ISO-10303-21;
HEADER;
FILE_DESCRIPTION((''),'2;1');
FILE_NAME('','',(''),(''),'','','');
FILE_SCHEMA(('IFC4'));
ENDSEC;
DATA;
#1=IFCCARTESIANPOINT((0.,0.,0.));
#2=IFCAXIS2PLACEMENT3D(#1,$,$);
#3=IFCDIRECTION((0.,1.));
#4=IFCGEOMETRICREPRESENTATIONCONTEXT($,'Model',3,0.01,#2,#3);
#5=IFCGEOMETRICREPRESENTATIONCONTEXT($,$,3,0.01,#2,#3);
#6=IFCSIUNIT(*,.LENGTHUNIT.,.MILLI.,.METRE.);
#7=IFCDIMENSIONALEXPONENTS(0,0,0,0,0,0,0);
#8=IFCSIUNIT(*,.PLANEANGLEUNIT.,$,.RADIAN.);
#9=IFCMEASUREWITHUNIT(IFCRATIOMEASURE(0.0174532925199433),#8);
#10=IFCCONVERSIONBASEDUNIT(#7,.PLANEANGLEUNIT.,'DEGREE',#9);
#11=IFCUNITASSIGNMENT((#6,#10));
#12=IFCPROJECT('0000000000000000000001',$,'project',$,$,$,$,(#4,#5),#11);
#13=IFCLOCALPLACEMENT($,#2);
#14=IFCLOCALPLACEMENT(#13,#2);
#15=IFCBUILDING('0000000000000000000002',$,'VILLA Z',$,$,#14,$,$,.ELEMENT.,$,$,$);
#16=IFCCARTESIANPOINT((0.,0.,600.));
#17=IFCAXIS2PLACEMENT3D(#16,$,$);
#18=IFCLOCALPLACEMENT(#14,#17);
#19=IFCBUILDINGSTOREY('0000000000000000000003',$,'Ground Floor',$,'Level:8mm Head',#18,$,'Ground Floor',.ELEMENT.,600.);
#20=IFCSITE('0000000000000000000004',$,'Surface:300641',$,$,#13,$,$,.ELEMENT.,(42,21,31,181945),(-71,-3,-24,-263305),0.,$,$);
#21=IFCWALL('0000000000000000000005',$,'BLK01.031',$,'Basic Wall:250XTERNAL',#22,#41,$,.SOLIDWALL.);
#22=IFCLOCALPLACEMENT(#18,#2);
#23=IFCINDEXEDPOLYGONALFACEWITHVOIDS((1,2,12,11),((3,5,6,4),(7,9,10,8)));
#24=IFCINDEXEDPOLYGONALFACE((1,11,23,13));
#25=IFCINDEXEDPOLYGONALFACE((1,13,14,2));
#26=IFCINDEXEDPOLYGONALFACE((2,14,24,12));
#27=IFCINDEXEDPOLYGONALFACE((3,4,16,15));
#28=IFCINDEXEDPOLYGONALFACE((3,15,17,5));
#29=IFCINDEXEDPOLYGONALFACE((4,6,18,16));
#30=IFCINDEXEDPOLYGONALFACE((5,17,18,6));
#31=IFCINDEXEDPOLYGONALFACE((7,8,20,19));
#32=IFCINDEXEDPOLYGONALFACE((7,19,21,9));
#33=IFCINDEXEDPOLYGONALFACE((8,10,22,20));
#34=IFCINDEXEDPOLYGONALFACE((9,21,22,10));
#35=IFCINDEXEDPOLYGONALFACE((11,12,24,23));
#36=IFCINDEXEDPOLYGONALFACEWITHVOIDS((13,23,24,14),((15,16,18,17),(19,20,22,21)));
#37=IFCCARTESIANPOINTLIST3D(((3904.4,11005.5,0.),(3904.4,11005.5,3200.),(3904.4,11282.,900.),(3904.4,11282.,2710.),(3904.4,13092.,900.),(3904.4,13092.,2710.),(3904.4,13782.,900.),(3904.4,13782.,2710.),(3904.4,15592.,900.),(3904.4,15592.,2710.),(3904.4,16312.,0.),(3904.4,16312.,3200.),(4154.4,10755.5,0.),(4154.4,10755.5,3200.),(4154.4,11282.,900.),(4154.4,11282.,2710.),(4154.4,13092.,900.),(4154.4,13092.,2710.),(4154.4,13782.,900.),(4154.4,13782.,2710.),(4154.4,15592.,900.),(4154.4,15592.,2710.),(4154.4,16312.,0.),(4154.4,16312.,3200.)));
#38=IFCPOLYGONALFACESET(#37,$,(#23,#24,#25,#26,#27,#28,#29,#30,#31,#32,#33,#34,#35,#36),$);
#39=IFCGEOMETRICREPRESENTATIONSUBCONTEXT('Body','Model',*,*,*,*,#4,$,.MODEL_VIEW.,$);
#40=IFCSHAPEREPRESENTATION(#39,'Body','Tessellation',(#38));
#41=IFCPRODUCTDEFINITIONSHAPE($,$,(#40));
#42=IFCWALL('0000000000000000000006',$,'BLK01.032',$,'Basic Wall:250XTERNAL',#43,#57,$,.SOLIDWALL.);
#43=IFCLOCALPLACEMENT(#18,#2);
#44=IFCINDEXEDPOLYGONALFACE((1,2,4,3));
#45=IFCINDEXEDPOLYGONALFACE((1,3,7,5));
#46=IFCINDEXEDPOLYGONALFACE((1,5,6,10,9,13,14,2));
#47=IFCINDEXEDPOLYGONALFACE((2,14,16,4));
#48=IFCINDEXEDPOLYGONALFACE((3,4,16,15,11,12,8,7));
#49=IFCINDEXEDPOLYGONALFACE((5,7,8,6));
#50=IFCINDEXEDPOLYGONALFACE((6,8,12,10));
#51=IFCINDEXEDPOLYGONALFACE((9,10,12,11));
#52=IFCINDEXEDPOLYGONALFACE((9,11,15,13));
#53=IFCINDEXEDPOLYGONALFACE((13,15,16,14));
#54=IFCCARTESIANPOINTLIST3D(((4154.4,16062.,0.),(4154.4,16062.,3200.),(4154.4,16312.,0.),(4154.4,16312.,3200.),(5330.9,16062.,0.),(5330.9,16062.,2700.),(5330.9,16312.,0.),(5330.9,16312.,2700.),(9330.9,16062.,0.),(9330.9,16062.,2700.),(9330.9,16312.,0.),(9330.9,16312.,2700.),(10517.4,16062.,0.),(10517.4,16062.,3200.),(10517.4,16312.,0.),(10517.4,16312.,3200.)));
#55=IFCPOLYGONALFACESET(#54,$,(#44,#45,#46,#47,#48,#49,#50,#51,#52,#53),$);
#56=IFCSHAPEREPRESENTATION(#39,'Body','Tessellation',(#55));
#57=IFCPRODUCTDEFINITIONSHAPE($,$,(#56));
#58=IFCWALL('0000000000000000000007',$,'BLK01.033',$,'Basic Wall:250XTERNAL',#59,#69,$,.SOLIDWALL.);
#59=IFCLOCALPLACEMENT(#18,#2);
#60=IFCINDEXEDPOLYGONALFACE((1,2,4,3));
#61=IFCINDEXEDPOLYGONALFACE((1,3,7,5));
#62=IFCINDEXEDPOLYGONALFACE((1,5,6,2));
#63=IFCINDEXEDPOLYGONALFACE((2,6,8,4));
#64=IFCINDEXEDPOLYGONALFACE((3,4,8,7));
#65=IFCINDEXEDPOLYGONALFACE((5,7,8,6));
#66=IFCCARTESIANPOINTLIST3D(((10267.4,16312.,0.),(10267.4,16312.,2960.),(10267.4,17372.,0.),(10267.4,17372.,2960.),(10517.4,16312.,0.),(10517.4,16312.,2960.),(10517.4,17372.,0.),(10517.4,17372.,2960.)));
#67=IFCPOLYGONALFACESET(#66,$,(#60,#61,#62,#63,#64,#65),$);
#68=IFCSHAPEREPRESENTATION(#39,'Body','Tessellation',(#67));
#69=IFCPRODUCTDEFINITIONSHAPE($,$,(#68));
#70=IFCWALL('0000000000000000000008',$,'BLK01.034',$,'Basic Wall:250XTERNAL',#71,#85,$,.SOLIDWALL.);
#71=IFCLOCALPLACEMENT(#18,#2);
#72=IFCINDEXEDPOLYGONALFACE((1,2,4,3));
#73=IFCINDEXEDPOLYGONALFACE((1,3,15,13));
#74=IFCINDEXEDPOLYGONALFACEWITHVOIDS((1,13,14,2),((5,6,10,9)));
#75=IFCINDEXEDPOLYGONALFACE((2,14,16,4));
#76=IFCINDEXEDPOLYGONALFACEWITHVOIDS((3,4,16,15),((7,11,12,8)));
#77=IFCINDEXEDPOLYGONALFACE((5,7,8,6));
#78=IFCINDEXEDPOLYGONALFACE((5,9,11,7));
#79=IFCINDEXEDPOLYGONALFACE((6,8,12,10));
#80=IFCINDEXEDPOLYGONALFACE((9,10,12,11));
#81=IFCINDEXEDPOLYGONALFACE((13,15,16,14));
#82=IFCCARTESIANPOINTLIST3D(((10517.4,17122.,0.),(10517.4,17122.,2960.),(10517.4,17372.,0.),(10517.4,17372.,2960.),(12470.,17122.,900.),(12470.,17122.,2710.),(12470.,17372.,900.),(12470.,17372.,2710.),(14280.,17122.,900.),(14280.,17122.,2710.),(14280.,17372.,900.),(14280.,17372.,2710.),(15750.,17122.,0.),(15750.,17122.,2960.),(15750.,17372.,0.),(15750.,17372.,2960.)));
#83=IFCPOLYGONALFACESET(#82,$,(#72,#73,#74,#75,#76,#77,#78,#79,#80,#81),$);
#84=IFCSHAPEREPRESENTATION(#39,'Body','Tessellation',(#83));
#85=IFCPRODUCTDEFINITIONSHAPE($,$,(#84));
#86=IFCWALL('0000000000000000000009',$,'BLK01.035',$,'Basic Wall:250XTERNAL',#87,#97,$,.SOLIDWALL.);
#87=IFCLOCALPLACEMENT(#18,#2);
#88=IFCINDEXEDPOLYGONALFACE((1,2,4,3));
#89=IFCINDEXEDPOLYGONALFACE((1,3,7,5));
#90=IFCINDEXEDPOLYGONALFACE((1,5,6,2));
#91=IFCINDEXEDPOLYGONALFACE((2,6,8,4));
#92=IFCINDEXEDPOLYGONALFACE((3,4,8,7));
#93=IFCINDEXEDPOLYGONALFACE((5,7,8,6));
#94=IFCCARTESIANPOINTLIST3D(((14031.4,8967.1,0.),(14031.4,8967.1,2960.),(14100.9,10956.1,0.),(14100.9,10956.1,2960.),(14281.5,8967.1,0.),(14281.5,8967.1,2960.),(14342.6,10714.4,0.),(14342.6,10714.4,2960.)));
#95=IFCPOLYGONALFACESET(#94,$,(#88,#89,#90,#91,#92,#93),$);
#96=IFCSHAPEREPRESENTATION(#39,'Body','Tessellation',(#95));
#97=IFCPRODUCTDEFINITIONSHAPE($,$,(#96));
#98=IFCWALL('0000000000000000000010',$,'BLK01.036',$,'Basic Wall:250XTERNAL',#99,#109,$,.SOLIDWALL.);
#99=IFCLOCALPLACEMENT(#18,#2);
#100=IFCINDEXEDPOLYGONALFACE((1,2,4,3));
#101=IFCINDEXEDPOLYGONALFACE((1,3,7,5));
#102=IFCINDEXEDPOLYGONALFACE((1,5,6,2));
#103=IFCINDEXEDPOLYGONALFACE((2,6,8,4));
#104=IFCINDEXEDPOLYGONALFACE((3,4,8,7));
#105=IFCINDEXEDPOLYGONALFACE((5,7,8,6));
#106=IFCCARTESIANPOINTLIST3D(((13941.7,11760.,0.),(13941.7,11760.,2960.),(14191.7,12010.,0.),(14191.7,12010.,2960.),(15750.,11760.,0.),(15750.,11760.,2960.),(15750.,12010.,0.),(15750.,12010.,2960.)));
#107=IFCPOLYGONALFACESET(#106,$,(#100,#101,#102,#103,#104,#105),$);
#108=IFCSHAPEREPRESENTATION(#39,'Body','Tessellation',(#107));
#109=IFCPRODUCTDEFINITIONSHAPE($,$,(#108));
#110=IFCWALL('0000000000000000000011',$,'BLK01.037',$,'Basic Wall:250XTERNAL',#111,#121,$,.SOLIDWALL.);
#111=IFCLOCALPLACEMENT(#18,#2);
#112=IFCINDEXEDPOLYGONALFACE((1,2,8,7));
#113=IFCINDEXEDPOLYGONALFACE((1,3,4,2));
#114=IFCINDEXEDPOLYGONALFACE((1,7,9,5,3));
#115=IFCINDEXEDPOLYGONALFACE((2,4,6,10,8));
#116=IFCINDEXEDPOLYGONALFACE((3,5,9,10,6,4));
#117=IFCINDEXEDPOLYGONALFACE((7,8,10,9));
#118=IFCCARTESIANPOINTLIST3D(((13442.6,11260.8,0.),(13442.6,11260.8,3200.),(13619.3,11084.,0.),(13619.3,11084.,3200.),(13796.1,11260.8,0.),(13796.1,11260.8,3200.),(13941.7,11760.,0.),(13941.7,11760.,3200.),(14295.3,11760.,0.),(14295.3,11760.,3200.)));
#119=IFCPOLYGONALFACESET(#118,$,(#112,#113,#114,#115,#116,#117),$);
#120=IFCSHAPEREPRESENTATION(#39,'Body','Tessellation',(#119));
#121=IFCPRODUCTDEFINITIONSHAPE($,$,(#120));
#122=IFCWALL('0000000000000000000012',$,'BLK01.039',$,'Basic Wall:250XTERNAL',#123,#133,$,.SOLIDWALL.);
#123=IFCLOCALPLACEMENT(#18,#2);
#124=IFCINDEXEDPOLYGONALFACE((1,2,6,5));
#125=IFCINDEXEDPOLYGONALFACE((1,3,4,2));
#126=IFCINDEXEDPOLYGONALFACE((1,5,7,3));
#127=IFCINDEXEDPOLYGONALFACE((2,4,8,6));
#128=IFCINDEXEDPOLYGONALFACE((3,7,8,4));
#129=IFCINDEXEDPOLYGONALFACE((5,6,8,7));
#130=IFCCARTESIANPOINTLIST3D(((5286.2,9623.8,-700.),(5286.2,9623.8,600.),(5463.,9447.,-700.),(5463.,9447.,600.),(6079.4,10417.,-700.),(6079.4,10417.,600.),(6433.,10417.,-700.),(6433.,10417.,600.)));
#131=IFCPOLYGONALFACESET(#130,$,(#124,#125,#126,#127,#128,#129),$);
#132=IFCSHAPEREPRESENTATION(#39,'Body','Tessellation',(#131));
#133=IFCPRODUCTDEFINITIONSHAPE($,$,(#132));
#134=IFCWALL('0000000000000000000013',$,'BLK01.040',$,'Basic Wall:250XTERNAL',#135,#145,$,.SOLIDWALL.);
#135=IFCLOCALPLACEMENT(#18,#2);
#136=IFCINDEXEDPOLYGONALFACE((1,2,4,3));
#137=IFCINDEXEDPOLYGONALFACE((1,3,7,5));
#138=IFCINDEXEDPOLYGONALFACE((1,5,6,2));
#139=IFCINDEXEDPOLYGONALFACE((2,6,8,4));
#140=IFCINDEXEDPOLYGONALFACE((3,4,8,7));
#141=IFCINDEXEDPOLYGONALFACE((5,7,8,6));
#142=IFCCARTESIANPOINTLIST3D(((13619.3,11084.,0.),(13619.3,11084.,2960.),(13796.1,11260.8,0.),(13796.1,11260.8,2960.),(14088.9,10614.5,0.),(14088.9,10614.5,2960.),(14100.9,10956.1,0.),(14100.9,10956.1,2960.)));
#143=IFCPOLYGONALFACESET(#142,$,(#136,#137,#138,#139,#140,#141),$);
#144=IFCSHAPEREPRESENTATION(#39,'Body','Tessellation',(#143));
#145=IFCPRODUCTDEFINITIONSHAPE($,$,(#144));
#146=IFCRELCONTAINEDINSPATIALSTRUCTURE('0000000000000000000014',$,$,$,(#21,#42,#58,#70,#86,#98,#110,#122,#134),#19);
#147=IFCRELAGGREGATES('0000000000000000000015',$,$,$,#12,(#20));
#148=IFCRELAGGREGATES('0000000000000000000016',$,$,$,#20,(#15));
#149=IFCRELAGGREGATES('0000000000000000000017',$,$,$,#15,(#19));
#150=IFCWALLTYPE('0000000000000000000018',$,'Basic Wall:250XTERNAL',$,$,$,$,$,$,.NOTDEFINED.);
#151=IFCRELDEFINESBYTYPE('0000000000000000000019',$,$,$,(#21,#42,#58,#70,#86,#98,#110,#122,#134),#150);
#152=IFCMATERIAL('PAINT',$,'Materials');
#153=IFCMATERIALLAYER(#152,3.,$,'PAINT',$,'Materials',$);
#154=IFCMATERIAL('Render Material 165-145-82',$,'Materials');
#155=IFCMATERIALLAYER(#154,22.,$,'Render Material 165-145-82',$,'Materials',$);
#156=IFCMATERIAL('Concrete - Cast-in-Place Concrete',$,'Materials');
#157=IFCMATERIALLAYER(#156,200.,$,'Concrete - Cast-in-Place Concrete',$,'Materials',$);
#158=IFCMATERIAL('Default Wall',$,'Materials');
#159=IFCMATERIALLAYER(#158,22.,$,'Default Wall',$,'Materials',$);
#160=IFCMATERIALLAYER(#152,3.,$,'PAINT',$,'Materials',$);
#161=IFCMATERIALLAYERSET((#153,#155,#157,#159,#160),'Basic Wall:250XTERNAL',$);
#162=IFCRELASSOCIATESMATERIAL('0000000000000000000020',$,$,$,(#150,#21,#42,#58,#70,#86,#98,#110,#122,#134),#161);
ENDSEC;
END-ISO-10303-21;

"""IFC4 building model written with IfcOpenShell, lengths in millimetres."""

from ifc_helpers import new_model, entity, si_unit, converted_unit, direction, frame, frame_2d, origin, place, context, subcontext, project, spatial, polyline, rectangle, outline, extrude, clip, halfspace, bounded_halfspace, material, layer, layer_set, layer_usage, type_object, element, save


model = new_model("IFC4")

# Units and contexts
model_context = context("Model", 3, precision=0.01, world=origin(), true_north=direction((0.0, 1.0)))
context_of_model = context(None, 3, precision=0.01, world=origin(), true_north=direction((0.0, 1.0)))
body_context = subcontext(model_context, "Body", "Model", "MODEL_VIEW")
ifc_project = project(units=[si_unit("LENGTHUNIT", "METRE", prefix="MILLI"), converted_unit("PLANEANGLEUNIT", "DEGREE", entity("IfcRatioMeasure", 0.0174532925199433), si_unit("PLANEANGLEUNIT", "RADIAN"), dimensions=[0, 0, 0, 0, 0, 0, 0])], contexts=[model_context, context_of_model])

# Site, building, storey
site_placement = place(None, origin())
site = spatial("IfcSite", under=ifc_project, at=site_placement, Name="Surface:300641", CompositionType="ELEMENT", RefLatitude=(42, 21, 31, 181945), RefLongitude=(-71, -3, -24, -263305), RefElevation=0.0)
building_placement = place(site_placement, origin())
building = spatial("IfcBuilding", under=site, at=building_placement, Name="VILLA Z", CompositionType="ELEMENT")
storey_placement = place(building_placement, frame((0.0, 0.0, 600.0)))
storey = spatial("IfcBuildingStorey", under=building, at=storey_placement, Name="Ground Floor", ObjectType="Level:8mm Head", LongName="Ground Floor", CompositionType="ELEMENT", Elevation=600.0)

# Shared definitions
ifc_material_1 = material(Name="PAINT", Category="Materials")
ifc_layer_1 = layer(ifc_material_1, 3.0, Name="PAINT", Category="Materials")
ifc_material_2 = material(Name="Render Material 165-145-82", Category="Materials")
ifc_layer_2 = layer(ifc_material_2, 22.0, Name="Render Material 165-145-82", Category="Materials")
ifc_material_3 = material(Name="Concrete - Cast-in-Place Concrete", Category="Materials")
ifc_layer_3 = layer(ifc_material_3, 200.0, Name="Concrete - Cast-in-Place Concrete", Category="Materials")
ifc_material_4 = material(Name="Default Wall", Category="Materials")
ifc_layer_4 = layer(ifc_material_4, 22.0, Name="Default Wall", Category="Materials")
ifc_layer_5 = layer(ifc_material_1, 3.0, Name="PAINT", Category="Materials")
ifc_layer_set_1 = layer_set([ifc_layer_1, ifc_layer_2, ifc_layer_3, ifc_layer_4, ifc_layer_5], Name="Basic Wall:250XTERNAL")
wall_type_1 = type_object("IfcWallType", Name="Basic Wall:250XTERNAL", PredefinedType="NOTDEFINED", material=ifc_layer_set_1)

# Wall, openings
ifc_layer_usage_1 = layer_usage(ifc_layer_set_1, "AXIS2", "NEGATIVE", 125.0)
wall_1_placement = place(storey_placement, frame((4029.4, 10755.5, 0.0), z_axis=(0.0, 0.0, 1.0), x_axis=(0.0, 1.0, 0.0)))
wall_1 = element("IfcWall", 1, at=wall_1_placement, inside=storey, type_object=wall_type_1, material=ifc_layer_usage_1, Name="BLK01.031", ObjectType="Basic Wall:250XTERNAL", PredefinedType="SOLIDWALL", context=body_context, shape_type="Clipping", body=[
    clip(extrude(outline(polyline([(5556.5, -125.0), (5556.5, 125.0), (250.0, 125.0), (0.0, -125.0), (5306.5, -125.0), (5556.5, -125.0)])), origin(), (0.0, 0.0, 1.0), 3200.0), halfspace(origin(), True)),
])
opening_1_placement = place(wall_1_placement, frame((526.5, -125.0, 900.0)))
element("IfcOpeningElement", 2, at=opening_1_placement, cuts=wall_1, ObjectType="Opening", PredefinedType="OPENING", context=body_context, shape_type="SweptSolid", body=[
    extrude(rectangle(XDim=1810.0, YDim=1810.0, at=frame_2d((905.0, 905.0), x_axis=(-1.0, 0.0))), frame((0.0, 0.0, 0.0), z_axis=(0.0, 1.0, 0.0), x_axis=(0.0, 0.0, 1.0)), (0.0, 0.0, 1.0), 250.0),
])
opening_2_placement = place(wall_1_placement, frame((3026.5, -125.0, 900.0)))
element("IfcOpeningElement", 3, at=opening_2_placement, cuts=wall_1, ObjectType="Opening", PredefinedType="OPENING", context=body_context, shape_type="SweptSolid", body=[
    extrude(rectangle(XDim=1810.0, YDim=1810.0, at=frame_2d((905.0, 905.0), x_axis=(-1.0, 0.0))), frame((0.0, 0.0, 0.0), z_axis=(0.0, 1.0, 0.0), x_axis=(0.0, 0.0, 1.0)), (0.0, 0.0, 1.0), 250.0),
])

# Wall, opening
ifc_layer_usage_2 = layer_usage(ifc_layer_set_1, "AXIS2", "NEGATIVE", 125.0)
wall_2_placement = place(storey_placement, frame((4154.4, 16187.0, 0.0)))
wall_2 = element("IfcWall", 4, at=wall_2_placement, inside=storey, type_object=wall_type_1, material=ifc_layer_usage_2, Name="BLK01.032", ObjectType="Basic Wall:250XTERNAL", PredefinedType="SOLIDWALL", context=body_context, shape_type="Clipping", body=[
    clip(extrude(rectangle(XDim=6362.9, YDim=250.0, at=frame_2d((3181.5, 0.0), x_axis=(-1.0, 0.0))), origin(), (0.0, 0.0, 1.0), 3200.0), halfspace(origin(), True)),
])
opening_3_placement = place(wall_2_placement, frame((5176.5, 125.0, 0.0)))
element("IfcOpeningElement", 5, at=opening_3_placement, cuts=wall_2, ObjectType="Opening", PredefinedType="OPENING", context=body_context, shape_type="SweptSolid", body=[
    extrude(rectangle(XDim=2700.0, YDim=4000.0, at=frame_2d((1350.0, 2000.0), x_axis=(-1.0, 0.0))), frame((0.0, 0.0, 0.0), z_axis=(0.0, -1.0, 0.0), x_axis=(0.0, 0.0, 1.0)), (0.0, 0.0, 1.0), 250.0),
])

# Wall
ifc_layer_usage_3 = layer_usage(ifc_layer_set_1, "AXIS2", "NEGATIVE", 125.0)
wall_3_placement = place(storey_placement, frame((10392.4, 16312.0, 0.0), z_axis=(0.0, 0.0, 1.0), x_axis=(0.0, 1.0, 0.0)))
element("IfcWall", 6, at=wall_3_placement, inside=storey, type_object=wall_type_1, material=ifc_layer_usage_3, Name="BLK01.033", ObjectType="Basic Wall:250XTERNAL", PredefinedType="SOLIDWALL", context=body_context, shape_type="Clipping", body=[
    clip(extrude(rectangle(XDim=1060.0, YDim=250.0, at=frame_2d((530.0, 0.0), x_axis=(-1.0, 0.0))), origin(), (0.0, 0.0, 1.0), 2960.0), bounded_halfspace(frame((0.0, -125.0, 2960.0), z_axis=(0.0, 0.0, -1.0), x_axis=(-1.0, 0.0, 0.0)), True, frame((0.0, -125.0, 2960.0)), polyline([(0.0, 0.0), (810.0, 0.0), (1060.0, 0.0), (1060.0, 250.0), (0.0, 250.0), (0.0, 0.0)]))),
])

# Wall, opening
ifc_layer_usage_4 = layer_usage(ifc_layer_set_1, "AXIS2", "NEGATIVE", 125.0)
wall_4_placement = place(storey_placement, frame((10517.4, 17247.0, 0.0)))
wall_4 = element("IfcWall", 7, at=wall_4_placement, inside=storey, type_object=wall_type_1, material=ifc_layer_usage_4, Name="BLK01.034", ObjectType="Basic Wall:250XTERNAL", PredefinedType="SOLIDWALL", context=body_context, shape_type="Clipping", body=[
    clip(extrude(rectangle(XDim=5232.6, YDim=250.0, at=frame_2d((2616.3, 0.0), x_axis=(-1.0, 0.0))), origin(), (0.0, 0.0, 1.0), 2960.0), bounded_halfspace(frame((0.0, -125.0, 2960.0), z_axis=(0.0, 0.0, -1.0), x_axis=(0.0, -1.0, 0.0)), True, frame((0.0, -125.0, 2960.0)), polyline([(0.0, 0.0), (5232.6, 0.0), (5232.6, 250.0), (0.0, 250.0), (0.0, 0.0)]))),
])
opening_4_placement = place(wall_4_placement, frame((1952.6, -125.0, 900.0)))
element("IfcOpeningElement", 8, at=opening_4_placement, cuts=wall_4, ObjectType="Opening", PredefinedType="OPENING", context=body_context, shape_type="SweptSolid", body=[
    extrude(rectangle(XDim=1810.0, YDim=1810.0, at=frame_2d((905.0, 905.0), x_axis=(-1.0, 0.0))), frame((0.0, 0.0, 0.0), z_axis=(0.0, 1.0, 0.0), x_axis=(0.0, 0.0, 1.0)), (0.0, 0.0, 1.0), 250.0),
])

# Walls
ifc_layer_usage_5 = layer_usage(ifc_layer_set_1, "AXIS2", "NEGATIVE", 125.0)
wall_5_placement = place(storey_placement, frame((14156.3, 8962.8, 0.0), z_axis=(0.0, 0.0, 1.0), x_axis=(0.034899, 0.999391, 0.0)))
element("IfcWall", 9, at=wall_5_placement, inside=storey, type_object=wall_type_1, material=ifc_layer_usage_5, Name="BLK01.035", ObjectType="Basic Wall:250XTERNAL", PredefinedType="SOLIDWALL", context=body_context, shape_type="Clipping", body=[
    clip(clip(extrude(outline(polyline([(1757.0, -125.0), (1990.2, 125.0), (1648.3, 125.0), (0.0, 125.0), (8.7, -125.0), (1757.0, -125.0)])), origin(), (0.0, 0.0, 1.0), 2960.0), bounded_halfspace(frame((8.7, -125.0, 2960.0), z_axis=(0.0, 0.0, -1.0), x_axis=(-0.999391, -0.034899, 0.0)), True, frame((8.7, -125.0, 2960.0)), polyline([(0.0, 0.0), (1748.3, 0.0), (1981.4, 250.0), (1639.6, 250.0), (-8.7, 250.0), (0.0, 0.0)]))), halfspace(origin(), True)),
])
ifc_layer_usage_6 = layer_usage(ifc_layer_set_1, "AXIS2", "NEGATIVE", 125.0)
wall_6_placement = place(storey_placement, frame((13941.7, 11885.0, 0.0)))
element("IfcWall", 10, at=wall_6_placement, inside=storey, type_object=wall_type_1, material=ifc_layer_usage_6, Name="BLK01.036", ObjectType="Basic Wall:250XTERNAL", PredefinedType="SOLIDWALL", context=body_context, shape_type="Clipping", body=[
    clip(clip(extrude(outline(polyline([(1808.3, -125.0), (1808.3, 125.0), (250.0, 125.0), (0.0, -125.0), (353.6, -125.0), (1808.3, -125.0)])), origin(), (0.0, 0.0, 1.0), 2960.0), bounded_halfspace(frame((0.0, -125.0, 2960.0), z_axis=(0.0, 0.0, -1.0), x_axis=(0.0, -1.0, 0.0)), True, frame((0.0, -125.0, 2960.0)), polyline([(0.0, 0.0), (1808.3, 0.0), (1808.3, 250.0), (250.0, 250.0), (0.0, 0.0)]))), halfspace(origin(), True)),
])
ifc_layer_usage_7 = layer_usage(ifc_layer_set_1, "AXIS2", "NEGATIVE", 125.0)
wall_7_placement = place(storey_placement, frame((14206.9, 11848.4, 0.0), z_axis=(0.0, 0.0, 1.0), x_axis=(-0.707107, -0.707107, 0.0)))
element("IfcWall", 11, at=wall_7_placement, inside=storey, type_object=wall_type_1, material=ifc_layer_usage_7, Name="BLK01.037", ObjectType="Basic Wall:250XTERNAL", PredefinedType="SOLIDWALL", context=body_context, shape_type="SweptSolid", body=[
    extrude(outline(polyline([(955.9, -125.0), (955.9, 125.0), (705.9, 125.0), (0.0, 125.0), (250.0, -125.0), (955.9, -125.0)])), origin(), (0.0, 0.0, 1.0), 3200.0),
])
ifc_layer_usage_8 = layer_usage(ifc_layer_set_1, "AXIS2", "POSITIVE", -125.0)
wall_8_placement = place(storey_placement, frame((5286.2, 9447.0, -700.0), z_axis=(0.0, 0.0, 1.0), x_axis=(0.707107, 0.707107, 0.0)))
element("IfcWall", 12, at=wall_8_placement, inside=storey, type_object=wall_type_1, material=ifc_layer_usage_8, Name="BLK01.039", ObjectType="Basic Wall:250XTERNAL", PredefinedType="SOLIDWALL", context=body_context, shape_type="SweptSolid", body=[
    extrude(outline(polyline([(1496.8, -125.0), (1246.8, 125.0), (125.0, 125.0), (125.0, -125.0), (1496.8, -125.0)])), origin(), (0.0, 0.0, 1.0), 1300.0),
])
ifc_layer_usage_9 = layer_usage(ifc_layer_set_1, "AXIS2", "POSITIVE", -125.0)
wall_9_placement = place(storey_placement, frame((14177.3, 10702.9, 0.0), z_axis=(0.0, 0.0, 1.0), x_axis=(-0.707107, 0.707107, 0.0)))
element("IfcWall", 13, at=wall_9_placement, inside=storey, type_object=wall_type_1, material=ifc_layer_usage_9, Name="BLK01.040", ObjectType="Basic Wall:250XTERNAL", PredefinedType="SOLIDWALL", context=body_context, shape_type="Clipping", body=[
    clip(clip(extrude(outline(polyline([(664.1, -125.0), (664.1, 125.0), (0.0, 125.0), (233.1, -125.0), (664.1, -125.0)])), origin(), (0.0, 0.0, 1.0), 2960.0), bounded_halfspace(frame((233.1, -125.0, 2960.0), z_axis=(0.0, 0.0, -1.0), x_axis=(-0.707107, 0.707107, 0.0)), True, frame((233.1, -125.0, 2960.0)), polyline([(0.0, 0.0), (431.0, 0.0), (431.0, 250.0), (-233.1, 250.0), (0.0, 0.0)]))), halfspace(origin(), True)),
])

save(model, "model.ifc")
